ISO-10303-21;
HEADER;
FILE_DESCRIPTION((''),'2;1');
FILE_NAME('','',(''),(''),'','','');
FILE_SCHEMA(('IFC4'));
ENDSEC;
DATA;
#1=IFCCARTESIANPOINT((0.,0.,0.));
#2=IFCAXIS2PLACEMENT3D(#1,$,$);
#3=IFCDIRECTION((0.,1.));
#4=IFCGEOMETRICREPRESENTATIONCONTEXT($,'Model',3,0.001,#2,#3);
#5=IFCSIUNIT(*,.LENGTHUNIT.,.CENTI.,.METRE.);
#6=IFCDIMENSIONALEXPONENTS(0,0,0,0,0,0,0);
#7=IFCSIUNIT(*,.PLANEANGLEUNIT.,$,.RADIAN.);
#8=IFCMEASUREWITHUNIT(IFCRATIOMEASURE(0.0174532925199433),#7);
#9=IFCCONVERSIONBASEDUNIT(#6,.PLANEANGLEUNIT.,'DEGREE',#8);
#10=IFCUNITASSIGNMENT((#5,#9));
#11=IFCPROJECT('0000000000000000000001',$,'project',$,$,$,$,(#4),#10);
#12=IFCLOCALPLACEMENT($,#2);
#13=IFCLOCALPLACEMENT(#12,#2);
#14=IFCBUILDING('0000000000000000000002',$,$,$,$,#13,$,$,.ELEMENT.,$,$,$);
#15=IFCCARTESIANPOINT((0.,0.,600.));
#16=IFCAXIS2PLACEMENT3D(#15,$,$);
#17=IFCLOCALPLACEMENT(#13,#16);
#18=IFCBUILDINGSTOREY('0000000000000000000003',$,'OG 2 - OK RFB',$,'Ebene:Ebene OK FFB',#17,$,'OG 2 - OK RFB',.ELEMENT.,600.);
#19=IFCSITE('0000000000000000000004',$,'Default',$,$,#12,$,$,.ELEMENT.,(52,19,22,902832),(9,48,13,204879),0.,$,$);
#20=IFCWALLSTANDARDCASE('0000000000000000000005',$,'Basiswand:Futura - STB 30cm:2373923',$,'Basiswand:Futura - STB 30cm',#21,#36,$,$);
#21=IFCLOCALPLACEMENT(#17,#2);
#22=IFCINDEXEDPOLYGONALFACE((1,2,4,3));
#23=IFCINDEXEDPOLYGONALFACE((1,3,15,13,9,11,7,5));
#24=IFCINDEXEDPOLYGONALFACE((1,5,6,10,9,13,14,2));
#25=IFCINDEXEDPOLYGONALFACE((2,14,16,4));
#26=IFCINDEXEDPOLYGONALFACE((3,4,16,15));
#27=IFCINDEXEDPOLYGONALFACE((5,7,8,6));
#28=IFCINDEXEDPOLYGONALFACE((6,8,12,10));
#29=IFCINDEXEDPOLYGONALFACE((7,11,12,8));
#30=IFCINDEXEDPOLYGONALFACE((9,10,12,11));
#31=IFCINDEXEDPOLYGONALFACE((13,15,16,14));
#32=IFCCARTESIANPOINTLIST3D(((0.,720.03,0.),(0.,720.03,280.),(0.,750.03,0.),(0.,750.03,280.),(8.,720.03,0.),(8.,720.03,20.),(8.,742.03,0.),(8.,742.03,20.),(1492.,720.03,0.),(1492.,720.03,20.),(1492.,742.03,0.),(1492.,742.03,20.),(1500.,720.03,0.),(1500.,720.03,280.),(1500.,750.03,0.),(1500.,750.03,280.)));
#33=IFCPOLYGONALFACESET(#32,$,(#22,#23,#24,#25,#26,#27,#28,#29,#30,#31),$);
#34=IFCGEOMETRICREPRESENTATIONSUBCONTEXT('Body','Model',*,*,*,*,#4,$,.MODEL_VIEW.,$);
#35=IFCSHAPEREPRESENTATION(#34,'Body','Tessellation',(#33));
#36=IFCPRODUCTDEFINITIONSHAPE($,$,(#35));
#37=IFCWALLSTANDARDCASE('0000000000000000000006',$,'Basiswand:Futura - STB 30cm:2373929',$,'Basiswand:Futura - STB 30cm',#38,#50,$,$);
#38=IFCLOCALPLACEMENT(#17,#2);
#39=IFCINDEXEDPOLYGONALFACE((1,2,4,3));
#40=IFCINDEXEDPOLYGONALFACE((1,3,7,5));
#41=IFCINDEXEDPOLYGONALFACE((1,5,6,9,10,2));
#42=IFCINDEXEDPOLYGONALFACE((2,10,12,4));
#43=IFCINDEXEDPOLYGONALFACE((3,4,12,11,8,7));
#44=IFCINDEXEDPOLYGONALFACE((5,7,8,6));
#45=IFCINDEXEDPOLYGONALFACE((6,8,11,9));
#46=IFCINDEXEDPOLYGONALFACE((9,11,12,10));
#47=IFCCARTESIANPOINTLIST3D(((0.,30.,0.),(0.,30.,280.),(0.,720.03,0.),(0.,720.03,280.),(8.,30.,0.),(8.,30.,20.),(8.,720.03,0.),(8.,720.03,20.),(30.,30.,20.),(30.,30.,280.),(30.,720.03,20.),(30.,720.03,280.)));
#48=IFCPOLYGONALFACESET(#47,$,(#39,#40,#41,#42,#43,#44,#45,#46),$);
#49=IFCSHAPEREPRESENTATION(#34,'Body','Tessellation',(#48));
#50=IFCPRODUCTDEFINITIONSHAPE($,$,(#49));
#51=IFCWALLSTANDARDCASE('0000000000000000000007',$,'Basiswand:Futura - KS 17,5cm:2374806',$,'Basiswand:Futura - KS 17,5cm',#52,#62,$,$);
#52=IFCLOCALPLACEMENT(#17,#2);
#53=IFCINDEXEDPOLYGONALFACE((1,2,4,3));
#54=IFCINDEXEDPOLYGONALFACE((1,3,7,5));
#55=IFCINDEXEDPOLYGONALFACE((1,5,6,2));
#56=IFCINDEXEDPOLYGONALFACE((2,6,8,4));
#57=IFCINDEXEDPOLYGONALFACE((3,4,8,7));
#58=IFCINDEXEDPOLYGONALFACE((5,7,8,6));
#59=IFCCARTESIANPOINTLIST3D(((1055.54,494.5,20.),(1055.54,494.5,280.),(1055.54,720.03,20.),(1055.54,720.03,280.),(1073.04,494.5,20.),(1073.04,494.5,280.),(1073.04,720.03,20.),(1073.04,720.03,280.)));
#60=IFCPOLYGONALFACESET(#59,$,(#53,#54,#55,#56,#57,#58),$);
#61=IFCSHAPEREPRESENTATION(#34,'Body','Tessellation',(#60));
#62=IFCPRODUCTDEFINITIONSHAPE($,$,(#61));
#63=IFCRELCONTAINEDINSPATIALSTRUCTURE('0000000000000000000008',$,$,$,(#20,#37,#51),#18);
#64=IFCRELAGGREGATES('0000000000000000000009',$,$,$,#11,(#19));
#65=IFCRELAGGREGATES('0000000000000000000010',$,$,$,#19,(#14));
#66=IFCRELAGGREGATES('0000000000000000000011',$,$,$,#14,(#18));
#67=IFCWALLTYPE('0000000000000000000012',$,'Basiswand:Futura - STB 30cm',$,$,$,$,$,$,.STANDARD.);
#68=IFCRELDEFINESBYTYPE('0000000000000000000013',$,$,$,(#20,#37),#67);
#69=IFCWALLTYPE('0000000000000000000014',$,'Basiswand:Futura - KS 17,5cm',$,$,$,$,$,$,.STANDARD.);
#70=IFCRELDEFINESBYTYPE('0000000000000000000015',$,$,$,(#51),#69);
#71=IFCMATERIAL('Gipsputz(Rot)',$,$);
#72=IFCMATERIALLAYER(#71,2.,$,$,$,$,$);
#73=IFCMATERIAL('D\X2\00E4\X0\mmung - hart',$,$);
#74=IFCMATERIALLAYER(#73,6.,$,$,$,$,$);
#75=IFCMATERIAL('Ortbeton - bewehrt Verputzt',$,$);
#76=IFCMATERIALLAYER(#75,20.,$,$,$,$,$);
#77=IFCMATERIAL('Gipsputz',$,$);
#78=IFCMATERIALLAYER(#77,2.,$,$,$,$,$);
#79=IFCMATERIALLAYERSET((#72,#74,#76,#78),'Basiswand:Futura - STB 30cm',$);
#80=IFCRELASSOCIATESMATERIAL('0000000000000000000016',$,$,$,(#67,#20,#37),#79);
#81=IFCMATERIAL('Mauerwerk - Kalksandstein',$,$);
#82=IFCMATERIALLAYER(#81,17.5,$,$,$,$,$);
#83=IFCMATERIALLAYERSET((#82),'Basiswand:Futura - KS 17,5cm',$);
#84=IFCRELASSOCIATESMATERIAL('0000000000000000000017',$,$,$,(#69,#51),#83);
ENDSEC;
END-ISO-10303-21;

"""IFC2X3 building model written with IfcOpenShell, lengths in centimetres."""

from ifc_helpers import new_model, entity, si_unit, converted_unit, direction, frame, frame_2d, origin, place, context, subcontext, project, spatial, polyline, rectangle, extrude, clip, bounded_halfspace, material, layer, layer_set, layer_usage, type_object, element, save


model = new_model("IFC2X3")

# Units and contexts
model_context = context("Model", 3, precision=0.001, world=origin(), true_north=direction((0.0, 1.0)))
body_context = subcontext(model_context, "Body", "Model", "MODEL_VIEW")
ifc_project = project(units=[si_unit("LENGTHUNIT", "METRE", prefix="CENTI"), converted_unit("PLANEANGLEUNIT", "DEGREE", entity("IfcRatioMeasure", 0.0174532925199433), si_unit("PLANEANGLEUNIT", "RADIAN"), dimensions=[0, 0, 0, 0, 0, 0, 0])], contexts=[model_context])

# Site, building, storey
site_placement = place(None, frame((0.0, 0.0, 0.0)))
site = spatial("IfcSite", under=ifc_project, at=site_placement, Name="Default", CompositionType="ELEMENT", RefLatitude=(52, 19, 22, 902832), RefLongitude=(9, 48, 13, 204879), RefElevation=0.0)
building_placement = place(site_placement, origin())
building = spatial("IfcBuilding", under=site, at=building_placement, CompositionType="ELEMENT")
storey_placement = place(building_placement, frame((0.0, 0.0, 600.0)))
storey = spatial("IfcBuildingStorey", under=building, at=storey_placement, Name="OG 2 - OK RFB", ObjectType="Ebene:Ebene OK FFB", LongName="OG 2 - OK RFB", CompositionType="ELEMENT", Elevation=600.0)

# Wall, opening
ifc_material_1 = material(Name="Gipsputz(Rot)")
ifc_layer_1 = layer(ifc_material_1, 2.0)
ifc_material_2 = material(Name="Dämmung - hart")
ifc_layer_2 = layer(ifc_material_2, 6.0)
ifc_material_3 = material(Name="Ortbeton - bewehrt Verputzt")
ifc_layer_3 = layer(ifc_material_3, 20.0)
ifc_material_4 = material(Name="Gipsputz")
ifc_layer_4 = layer(ifc_material_4, 2.0)
ifc_layer_set_1 = layer_set([ifc_layer_1, ifc_layer_2, ifc_layer_3, ifc_layer_4], Name="Basiswand:Futura - STB 30cm")
ifc_layer_usage_1 = layer_usage(ifc_layer_set_1, "AXIS2", "NEGATIVE", 15.0)
wall_type_1 = type_object("IfcWallType", Name="Basiswand:Futura - STB 30cm", PredefinedType="STANDARD", material=ifc_layer_set_1)
wall_1_placement = place(storey_placement, frame((0.0, 735.03, 0.0)))
wall_1 = element("IfcWallStandardCase", 1, at=wall_1_placement, inside=storey, type_object=wall_type_1, material=ifc_layer_usage_1, Name="Basiswand:Futura - STB 30cm:2373923", ObjectType="Basiswand:Futura - STB 30cm", context=body_context, shape_type="Clipping", body=[
    clip(extrude(rectangle(XDim=1500.0, YDim=30.0, at=frame_2d((750.0, 0.0), x_axis=(-1.0, 0.0))), origin(), (0.0, 0.0, 1.0), 280.0), bounded_halfspace(frame((0.0, -15.0, 280.0), z_axis=(0.0, 0.0, 1.0), x_axis=(-1.0, 0.0, 0.0)), False, frame((0.0, -15.0, 280.0)), polyline([(0.0, 0.0), (30.0, 0.0), (1055.54, 0.0), (1073.04, 0.0), (1470.0, 0.0), (1500.0, 0.0), (1500.0, 30.0), (0.0, 30.0), (0.0, 0.0)]))),
])
opening_placement = place(storey_placement, frame((0.0, 735.03, 0.0)))
element("IfcOpeningElement", 2, at=opening_placement, cuts=wall_1, ObjectType="Opening", context=body_context, shape_type="SweptSolid", body=[
    extrude(rectangle(XDim=20.0, YDim=22.0, at=frame_2d((0.0, 0.0), x_axis=(0.0, 1.0))), frame((8.0, -4.0, 10.0), z_axis=(1.0, 0.0, 0.0), x_axis=(0.0, -1.0, 0.0)), (0.0, 0.0, 1.0), 1484.0),
])

# Walls
ifc_layer_usage_2 = layer_usage(ifc_layer_set_1, "AXIS2", "NEGATIVE", 15.0)
wall_2_placement = place(storey_placement, frame((15.0, 30.0, 0.0), z_axis=(0.0, 0.0, 1.0), x_axis=(0.0, 1.0, 0.0)))
element("IfcWallStandardCase", 3, at=wall_2_placement, inside=storey, type_object=wall_type_1, material=ifc_layer_usage_2, Name="Basiswand:Futura - STB 30cm:2373929", ObjectType="Basiswand:Futura - STB 30cm", context=body_context, shape_type="Clipping", body=[
    clip(clip(clip(extrude(rectangle(XDim=690.03, YDim=30.0, at=frame_2d((345.02, 0.0), x_axis=(-1.0, 0.0))), origin(), (0.0, 0.0, 1.0), 280.0), bounded_halfspace(frame((0.0, -15.0, 280.0), z_axis=(0.0, 0.0, 1.0), x_axis=(0.0, 1.0, 0.0)), False, frame((0.0, -15.0, 280.0)), polyline([(0.0, 0.0), (690.03, 0.0), (690.03, 30.0), (0.0, 30.0), (0.0, 0.0)]))), bounded_halfspace(frame((0.0, 7.0, 20.0)), True, frame((0.0, 7.0, 20.0)), polyline([(0.0, 0.0), (0.0, -22.0), (690.03, -22.0), (690.03, 0.0), (0.0, 0.0)]))), bounded_halfspace(frame((690.03, 7.0, 20.0), z_axis=(0.0, 1.0, 0.0), x_axis=(0.0, 0.0, 1.0)), True, frame((690.03, 7.0, 20.0), z_axis=(0.0, 1.0, 0.0), x_axis=(0.0, 0.0, 1.0)), polyline([(0.0, 0.0), (-20.0, 0.0), (-20.0, -690.03), (0.0, -690.03), (0.0, 0.0)]))),
])
ifc_material_5 = material(Name="Mauerwerk - Kalksandstein")
ifc_layer_5 = layer(ifc_material_5, 17.5)
ifc_layer_set_2 = layer_set([ifc_layer_5], Name="Basiswand:Futura - KS 17,5cm")
ifc_layer_usage_3 = layer_usage(ifc_layer_set_2, "AXIS2", "NEGATIVE", 8.75)
wall_type_2 = type_object("IfcWallType", Name="Basiswand:Futura - KS 17,5cm", PredefinedType="STANDARD", material=ifc_layer_set_2)
wall_3_placement = place(storey_placement, frame((1064.29, 720.03, 20.0), z_axis=(0.0, 0.0, 1.0), x_axis=(0.0, -1.0, 0.0)))
element("IfcWallStandardCase", 4, at=wall_3_placement, inside=storey, type_object=wall_type_2, material=ifc_layer_usage_3, Name="Basiswand:Futura - KS 17,5cm:2374806", ObjectType="Basiswand:Futura - KS 17,5cm", context=body_context, shape_type="Clipping", body=[
    clip(extrude(rectangle(XDim=225.54, YDim=17.5, at=frame_2d((112.77, 0.0), x_axis=(-1.0, 0.0))), origin(), (0.0, 0.0, 1.0), 260.0), bounded_halfspace(frame((225.54, -8.75, 0.0), z_axis=(0.0, 0.0, 1.0), x_axis=(-1.0, 0.0, 0.0)), True, frame((225.54, -8.75, 0.0), z_axis=(0.0, 0.0, 1.0), x_axis=(-1.0, 0.0, 0.0)), polyline([(0.0, 0.0), (0.0, -17.5), (17.5, -17.5), (225.54, -17.5), (225.54, 0.0), (0.0, 0.0)]))),
])

save(model, "model.ifc")
